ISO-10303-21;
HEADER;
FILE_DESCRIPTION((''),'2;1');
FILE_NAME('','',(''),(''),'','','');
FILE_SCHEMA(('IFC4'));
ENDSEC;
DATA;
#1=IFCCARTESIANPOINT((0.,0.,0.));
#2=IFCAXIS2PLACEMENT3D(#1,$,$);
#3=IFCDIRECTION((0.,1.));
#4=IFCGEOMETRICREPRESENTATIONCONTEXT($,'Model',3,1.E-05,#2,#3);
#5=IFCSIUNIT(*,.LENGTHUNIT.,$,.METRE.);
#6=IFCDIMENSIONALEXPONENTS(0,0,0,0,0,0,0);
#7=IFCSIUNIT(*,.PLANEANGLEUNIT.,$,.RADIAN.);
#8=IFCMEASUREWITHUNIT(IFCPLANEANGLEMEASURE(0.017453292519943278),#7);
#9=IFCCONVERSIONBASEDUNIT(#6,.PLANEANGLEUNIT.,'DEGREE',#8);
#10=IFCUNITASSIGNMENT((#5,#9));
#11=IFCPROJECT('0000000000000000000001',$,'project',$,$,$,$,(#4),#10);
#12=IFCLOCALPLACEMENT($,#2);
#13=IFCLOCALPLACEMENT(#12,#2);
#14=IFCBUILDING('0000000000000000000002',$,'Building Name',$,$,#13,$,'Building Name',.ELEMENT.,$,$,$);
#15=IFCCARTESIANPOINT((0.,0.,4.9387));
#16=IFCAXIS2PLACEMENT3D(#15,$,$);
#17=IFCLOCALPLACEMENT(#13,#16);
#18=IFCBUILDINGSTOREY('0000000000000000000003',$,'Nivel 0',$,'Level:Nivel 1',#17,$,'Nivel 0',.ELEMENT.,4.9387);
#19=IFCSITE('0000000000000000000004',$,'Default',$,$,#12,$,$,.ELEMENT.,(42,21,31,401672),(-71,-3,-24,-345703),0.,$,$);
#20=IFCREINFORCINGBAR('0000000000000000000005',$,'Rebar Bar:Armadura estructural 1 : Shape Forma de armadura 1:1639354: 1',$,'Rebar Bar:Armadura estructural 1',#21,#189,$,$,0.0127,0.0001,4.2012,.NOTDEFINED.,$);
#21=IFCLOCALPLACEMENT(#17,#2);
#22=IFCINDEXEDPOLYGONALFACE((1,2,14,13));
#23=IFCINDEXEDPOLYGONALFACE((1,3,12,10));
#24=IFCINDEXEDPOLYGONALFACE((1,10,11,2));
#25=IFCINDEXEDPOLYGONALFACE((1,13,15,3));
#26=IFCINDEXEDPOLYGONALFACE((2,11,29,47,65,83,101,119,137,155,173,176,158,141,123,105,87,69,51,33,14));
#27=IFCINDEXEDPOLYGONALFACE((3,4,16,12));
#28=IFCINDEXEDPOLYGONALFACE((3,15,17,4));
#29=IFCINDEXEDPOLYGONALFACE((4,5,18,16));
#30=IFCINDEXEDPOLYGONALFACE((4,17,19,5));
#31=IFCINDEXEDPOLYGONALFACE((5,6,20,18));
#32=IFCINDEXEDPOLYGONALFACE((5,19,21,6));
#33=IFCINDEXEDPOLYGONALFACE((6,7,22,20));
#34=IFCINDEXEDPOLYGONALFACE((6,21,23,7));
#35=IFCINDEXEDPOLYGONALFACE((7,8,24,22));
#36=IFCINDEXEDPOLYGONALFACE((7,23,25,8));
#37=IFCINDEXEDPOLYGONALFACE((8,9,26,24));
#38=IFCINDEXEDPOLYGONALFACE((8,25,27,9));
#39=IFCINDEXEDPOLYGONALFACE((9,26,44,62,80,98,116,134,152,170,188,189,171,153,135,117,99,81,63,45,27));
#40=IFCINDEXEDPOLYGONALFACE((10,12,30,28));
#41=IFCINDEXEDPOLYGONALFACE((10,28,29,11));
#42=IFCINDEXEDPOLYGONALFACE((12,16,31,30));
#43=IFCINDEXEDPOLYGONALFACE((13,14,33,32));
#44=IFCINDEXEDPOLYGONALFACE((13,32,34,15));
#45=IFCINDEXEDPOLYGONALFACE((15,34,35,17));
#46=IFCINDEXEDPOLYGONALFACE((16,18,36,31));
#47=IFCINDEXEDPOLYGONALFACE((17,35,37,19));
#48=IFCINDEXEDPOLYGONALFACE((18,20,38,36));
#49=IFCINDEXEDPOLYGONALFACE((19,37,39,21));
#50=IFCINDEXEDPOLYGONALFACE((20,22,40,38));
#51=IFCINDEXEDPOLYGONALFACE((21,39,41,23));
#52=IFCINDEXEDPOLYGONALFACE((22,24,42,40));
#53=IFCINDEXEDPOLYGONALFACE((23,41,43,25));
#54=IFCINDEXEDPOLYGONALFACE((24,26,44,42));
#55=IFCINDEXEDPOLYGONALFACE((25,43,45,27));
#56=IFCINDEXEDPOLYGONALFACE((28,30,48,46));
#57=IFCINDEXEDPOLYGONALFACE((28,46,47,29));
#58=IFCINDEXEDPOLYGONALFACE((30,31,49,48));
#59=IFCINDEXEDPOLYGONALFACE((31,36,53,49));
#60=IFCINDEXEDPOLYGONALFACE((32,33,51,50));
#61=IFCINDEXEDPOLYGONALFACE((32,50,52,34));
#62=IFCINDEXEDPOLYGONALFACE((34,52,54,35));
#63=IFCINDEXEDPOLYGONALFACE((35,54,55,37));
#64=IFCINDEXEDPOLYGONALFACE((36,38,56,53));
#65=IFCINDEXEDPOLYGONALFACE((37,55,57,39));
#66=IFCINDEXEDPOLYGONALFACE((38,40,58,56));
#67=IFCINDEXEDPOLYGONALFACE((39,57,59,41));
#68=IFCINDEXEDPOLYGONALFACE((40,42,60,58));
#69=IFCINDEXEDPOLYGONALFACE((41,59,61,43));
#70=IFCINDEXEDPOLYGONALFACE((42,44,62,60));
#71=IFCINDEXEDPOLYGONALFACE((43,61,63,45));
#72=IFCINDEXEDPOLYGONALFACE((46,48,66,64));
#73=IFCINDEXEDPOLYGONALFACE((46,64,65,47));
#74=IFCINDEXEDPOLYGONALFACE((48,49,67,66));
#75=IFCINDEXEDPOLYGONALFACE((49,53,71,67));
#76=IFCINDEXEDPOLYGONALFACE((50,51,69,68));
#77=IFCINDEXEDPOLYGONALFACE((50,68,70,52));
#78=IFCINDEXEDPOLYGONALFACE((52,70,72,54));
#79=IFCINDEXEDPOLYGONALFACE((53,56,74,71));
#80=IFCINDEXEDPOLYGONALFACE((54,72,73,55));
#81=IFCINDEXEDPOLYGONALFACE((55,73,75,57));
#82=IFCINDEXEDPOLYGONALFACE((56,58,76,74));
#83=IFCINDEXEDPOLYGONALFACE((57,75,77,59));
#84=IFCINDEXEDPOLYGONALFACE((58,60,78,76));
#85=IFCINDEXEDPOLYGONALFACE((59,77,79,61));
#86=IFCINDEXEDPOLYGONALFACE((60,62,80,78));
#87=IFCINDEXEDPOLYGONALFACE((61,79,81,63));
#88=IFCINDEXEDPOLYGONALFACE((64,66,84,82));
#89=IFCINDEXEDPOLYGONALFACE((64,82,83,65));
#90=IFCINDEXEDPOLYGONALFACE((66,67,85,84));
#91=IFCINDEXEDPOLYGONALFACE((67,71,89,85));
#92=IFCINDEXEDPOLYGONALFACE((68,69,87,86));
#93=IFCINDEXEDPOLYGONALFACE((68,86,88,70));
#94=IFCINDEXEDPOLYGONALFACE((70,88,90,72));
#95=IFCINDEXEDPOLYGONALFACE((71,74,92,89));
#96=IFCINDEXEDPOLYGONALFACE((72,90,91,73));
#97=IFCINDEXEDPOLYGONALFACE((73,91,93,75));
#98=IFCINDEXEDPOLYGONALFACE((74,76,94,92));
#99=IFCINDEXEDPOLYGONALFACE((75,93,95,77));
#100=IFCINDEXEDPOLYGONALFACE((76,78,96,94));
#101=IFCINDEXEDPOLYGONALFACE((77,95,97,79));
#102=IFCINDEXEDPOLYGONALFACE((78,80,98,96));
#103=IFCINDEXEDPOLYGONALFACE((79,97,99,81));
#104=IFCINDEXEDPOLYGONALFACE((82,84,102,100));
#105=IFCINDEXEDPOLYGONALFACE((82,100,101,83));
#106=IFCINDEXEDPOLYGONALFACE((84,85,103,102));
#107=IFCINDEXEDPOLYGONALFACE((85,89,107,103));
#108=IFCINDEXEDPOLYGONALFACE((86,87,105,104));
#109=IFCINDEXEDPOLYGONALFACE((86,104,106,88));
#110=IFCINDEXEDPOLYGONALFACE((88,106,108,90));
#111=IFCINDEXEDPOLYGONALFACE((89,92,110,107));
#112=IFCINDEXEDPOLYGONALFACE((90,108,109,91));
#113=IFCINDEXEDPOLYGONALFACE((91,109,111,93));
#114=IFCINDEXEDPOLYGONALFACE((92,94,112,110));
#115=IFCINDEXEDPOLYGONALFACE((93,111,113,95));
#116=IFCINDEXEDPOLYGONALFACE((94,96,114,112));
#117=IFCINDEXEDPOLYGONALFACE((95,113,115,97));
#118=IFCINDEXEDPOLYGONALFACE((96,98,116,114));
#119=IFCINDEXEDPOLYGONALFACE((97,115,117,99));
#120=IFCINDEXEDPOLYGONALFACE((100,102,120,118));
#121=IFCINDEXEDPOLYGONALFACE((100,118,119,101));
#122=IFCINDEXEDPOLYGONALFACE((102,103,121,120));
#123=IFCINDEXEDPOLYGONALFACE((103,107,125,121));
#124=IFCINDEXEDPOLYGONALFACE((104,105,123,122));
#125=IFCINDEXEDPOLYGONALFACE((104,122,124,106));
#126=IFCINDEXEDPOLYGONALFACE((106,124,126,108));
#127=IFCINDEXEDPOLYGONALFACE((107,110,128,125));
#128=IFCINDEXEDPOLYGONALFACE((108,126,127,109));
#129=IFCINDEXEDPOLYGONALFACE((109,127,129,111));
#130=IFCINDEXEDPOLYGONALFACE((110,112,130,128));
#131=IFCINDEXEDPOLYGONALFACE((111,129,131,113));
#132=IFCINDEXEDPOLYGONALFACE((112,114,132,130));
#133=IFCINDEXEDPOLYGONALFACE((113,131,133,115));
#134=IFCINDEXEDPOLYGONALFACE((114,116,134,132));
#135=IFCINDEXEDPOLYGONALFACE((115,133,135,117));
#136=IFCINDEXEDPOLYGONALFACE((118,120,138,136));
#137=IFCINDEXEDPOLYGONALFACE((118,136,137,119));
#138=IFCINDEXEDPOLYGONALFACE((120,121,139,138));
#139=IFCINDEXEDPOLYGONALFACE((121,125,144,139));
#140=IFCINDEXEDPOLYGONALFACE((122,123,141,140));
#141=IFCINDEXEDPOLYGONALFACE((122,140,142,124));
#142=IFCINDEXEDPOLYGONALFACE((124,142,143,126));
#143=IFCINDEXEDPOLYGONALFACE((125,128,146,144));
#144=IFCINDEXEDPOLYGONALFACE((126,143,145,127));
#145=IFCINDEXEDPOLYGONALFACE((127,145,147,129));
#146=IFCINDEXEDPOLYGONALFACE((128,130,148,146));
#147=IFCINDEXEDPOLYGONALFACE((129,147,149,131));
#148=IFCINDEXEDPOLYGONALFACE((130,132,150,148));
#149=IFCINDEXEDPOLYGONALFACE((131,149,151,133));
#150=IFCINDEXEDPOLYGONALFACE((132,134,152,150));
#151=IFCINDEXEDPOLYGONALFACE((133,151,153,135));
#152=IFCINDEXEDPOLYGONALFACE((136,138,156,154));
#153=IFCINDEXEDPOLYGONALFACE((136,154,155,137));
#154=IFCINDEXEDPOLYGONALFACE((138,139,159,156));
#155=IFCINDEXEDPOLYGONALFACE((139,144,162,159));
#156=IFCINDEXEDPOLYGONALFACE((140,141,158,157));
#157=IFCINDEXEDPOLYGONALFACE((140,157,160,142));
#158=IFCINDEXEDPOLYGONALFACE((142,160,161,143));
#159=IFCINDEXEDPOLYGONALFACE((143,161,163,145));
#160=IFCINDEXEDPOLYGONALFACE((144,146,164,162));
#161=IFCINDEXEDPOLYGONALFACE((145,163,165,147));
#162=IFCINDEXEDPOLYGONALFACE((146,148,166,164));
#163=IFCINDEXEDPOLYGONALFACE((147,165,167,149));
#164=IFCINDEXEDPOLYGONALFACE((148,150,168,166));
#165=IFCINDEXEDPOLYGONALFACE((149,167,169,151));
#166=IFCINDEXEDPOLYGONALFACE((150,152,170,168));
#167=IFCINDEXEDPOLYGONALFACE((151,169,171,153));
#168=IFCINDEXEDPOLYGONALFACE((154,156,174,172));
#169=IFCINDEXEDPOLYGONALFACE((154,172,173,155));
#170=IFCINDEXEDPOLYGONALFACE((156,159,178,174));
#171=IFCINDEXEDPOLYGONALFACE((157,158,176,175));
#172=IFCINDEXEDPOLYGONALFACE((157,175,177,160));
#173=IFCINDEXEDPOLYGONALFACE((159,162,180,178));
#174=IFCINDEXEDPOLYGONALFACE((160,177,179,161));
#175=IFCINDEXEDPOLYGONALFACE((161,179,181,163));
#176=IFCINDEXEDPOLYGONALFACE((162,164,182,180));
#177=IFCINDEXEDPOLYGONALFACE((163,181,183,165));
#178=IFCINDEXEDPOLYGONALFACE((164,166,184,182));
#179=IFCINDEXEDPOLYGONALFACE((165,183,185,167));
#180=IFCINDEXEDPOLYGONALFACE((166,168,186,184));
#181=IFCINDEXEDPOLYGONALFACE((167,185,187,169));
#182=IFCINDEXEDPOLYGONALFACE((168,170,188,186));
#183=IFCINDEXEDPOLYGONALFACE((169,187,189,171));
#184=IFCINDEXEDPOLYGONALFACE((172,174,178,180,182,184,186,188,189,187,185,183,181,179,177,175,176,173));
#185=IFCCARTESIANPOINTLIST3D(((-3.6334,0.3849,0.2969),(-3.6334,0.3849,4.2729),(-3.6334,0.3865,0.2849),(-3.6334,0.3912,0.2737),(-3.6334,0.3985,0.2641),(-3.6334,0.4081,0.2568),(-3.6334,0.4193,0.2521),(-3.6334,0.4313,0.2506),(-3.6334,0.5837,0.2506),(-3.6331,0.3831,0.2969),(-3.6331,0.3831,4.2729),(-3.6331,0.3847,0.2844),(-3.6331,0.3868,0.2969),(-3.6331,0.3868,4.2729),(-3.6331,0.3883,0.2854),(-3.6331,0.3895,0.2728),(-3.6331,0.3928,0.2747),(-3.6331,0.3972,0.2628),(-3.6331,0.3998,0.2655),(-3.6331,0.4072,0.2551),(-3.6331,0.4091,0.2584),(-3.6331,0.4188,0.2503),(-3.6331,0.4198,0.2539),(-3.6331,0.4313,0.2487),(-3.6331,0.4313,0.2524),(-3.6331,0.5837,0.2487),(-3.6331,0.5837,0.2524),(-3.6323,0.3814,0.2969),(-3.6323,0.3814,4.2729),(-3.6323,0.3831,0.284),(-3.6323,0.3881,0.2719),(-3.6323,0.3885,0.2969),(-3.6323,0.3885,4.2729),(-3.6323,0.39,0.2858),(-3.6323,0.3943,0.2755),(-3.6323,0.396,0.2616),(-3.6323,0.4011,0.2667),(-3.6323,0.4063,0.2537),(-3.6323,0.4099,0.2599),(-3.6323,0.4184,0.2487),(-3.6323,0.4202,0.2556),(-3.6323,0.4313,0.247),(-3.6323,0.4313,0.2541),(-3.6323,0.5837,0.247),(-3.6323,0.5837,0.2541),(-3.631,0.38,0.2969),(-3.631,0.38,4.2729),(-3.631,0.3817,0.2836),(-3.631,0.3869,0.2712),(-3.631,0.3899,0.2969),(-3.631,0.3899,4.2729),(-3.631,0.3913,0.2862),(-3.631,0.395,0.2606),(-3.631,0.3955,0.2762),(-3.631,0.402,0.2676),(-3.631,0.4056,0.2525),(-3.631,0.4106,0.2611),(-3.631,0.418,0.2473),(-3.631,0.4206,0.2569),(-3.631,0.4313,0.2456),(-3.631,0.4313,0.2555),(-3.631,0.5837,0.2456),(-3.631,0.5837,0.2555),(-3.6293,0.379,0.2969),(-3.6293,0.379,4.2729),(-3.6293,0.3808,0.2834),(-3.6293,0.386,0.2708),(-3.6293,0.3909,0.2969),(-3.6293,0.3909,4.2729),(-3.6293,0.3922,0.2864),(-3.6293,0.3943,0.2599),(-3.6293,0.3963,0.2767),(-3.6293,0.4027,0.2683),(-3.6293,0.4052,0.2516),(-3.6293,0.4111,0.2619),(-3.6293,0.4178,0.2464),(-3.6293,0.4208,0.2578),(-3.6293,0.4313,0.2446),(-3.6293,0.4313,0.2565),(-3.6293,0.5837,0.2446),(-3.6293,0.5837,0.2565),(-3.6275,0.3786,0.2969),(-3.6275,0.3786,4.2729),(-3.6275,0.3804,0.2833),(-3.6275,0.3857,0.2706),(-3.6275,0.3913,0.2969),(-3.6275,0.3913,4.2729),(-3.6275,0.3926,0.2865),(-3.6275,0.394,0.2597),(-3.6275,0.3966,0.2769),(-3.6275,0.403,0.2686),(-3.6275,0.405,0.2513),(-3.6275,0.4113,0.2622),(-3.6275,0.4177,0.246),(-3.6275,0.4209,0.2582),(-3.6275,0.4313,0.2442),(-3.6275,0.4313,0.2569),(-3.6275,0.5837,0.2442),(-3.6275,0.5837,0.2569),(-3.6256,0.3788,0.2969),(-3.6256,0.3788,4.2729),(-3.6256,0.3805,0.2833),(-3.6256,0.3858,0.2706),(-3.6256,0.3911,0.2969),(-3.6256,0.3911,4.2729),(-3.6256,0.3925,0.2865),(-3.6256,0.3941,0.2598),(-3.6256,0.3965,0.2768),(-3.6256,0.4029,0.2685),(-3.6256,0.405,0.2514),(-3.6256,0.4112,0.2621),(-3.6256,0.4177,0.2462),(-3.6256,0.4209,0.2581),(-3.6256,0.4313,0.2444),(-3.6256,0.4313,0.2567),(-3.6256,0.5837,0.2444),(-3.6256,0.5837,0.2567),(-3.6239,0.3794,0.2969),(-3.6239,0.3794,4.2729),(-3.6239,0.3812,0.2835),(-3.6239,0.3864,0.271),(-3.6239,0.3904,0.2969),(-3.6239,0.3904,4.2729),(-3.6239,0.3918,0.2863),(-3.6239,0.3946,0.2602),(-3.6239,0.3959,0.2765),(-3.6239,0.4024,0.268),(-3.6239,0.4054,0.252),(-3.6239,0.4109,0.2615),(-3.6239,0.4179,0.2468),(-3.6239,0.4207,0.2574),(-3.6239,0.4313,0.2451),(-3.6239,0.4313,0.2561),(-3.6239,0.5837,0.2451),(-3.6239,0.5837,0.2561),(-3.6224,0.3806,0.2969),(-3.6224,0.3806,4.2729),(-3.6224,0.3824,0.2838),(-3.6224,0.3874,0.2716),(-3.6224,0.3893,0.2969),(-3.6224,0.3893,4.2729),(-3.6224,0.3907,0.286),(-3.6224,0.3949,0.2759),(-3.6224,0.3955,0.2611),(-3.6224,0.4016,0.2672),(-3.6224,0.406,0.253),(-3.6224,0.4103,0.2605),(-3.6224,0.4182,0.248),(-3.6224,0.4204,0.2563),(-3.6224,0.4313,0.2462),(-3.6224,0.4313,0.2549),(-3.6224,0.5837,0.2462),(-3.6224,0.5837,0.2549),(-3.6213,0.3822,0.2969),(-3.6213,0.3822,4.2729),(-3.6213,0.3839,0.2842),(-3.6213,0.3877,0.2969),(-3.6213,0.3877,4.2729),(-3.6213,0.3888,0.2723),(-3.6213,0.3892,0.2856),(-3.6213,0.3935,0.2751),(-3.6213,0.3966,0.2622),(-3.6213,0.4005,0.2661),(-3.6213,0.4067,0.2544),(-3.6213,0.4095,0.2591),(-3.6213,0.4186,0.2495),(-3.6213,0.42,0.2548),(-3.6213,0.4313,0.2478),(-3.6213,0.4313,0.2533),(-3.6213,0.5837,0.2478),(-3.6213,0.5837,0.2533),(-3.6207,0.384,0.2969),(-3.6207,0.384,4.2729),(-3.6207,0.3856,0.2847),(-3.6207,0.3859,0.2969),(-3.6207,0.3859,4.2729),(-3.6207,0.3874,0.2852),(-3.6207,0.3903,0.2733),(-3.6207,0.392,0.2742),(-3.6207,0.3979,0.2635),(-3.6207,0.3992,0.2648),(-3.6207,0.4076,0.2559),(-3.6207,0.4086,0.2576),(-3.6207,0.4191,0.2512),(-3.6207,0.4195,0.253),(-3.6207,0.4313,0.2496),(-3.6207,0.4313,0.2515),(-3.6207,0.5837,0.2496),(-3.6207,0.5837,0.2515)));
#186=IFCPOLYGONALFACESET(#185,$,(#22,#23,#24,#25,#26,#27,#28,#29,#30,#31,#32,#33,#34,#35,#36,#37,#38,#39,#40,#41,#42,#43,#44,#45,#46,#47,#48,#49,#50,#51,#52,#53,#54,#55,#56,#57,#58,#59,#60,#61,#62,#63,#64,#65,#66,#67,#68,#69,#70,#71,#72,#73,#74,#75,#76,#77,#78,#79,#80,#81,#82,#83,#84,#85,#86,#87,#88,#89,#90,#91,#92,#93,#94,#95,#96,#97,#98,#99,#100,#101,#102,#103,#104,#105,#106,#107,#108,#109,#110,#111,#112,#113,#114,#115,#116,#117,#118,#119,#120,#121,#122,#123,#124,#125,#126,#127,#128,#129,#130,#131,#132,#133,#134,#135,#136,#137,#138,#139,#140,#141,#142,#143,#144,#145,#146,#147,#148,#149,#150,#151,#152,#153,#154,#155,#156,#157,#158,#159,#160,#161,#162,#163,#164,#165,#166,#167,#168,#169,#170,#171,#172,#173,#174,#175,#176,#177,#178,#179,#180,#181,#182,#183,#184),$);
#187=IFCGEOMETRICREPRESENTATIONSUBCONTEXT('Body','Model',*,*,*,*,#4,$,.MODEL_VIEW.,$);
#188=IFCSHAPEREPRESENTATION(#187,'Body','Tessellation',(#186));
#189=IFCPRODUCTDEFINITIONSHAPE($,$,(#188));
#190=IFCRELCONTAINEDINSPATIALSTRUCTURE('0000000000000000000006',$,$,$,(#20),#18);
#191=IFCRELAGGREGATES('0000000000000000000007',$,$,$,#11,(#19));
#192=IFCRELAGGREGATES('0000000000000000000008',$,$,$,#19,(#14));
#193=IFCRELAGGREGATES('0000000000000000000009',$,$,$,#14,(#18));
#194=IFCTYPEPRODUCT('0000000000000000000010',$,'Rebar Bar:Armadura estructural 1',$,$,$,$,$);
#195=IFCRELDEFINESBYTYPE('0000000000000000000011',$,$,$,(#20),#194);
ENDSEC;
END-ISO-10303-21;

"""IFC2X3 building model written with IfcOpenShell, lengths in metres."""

from ifc_helpers import new_model, entity, si_unit, converted_unit, direction, frame, origin, place, context, subcontext, project, spatial, type_object, element, save


model = new_model("IFC2X3")

# Units and contexts
model_context = context("Model", 3, precision=1e-05, world=origin(), true_north=direction((0.0, 1.0)))
body_context = subcontext(model_context, "Body", "Model", "MODEL_VIEW")
ifc_project = project(units=[si_unit("LENGTHUNIT", "METRE"), converted_unit("PLANEANGLEUNIT", "DEGREE", entity("IfcPlaneAngleMeasure", 0.017453292519943278), si_unit("PLANEANGLEUNIT", "RADIAN"), dimensions=[0, 0, 0, 0, 0, 0, 0])], contexts=[model_context])

# Site, building, storey
site_placement = place(None, origin())
site = spatial("IfcSite", under=ifc_project, at=site_placement, Name="Default", CompositionType="ELEMENT", RefLatitude=(42, 21, 31, 401672), RefLongitude=(-71, -3, -24, -345703), RefElevation=0.0)
building_placement = place(site_placement, origin())
building = spatial("IfcBuilding", under=site, at=building_placement, Name="Building Name", LongName="Building Name", CompositionType="ELEMENT")
storey_placement = place(building_placement, frame((0.0, 0.0, 4.9387)))
storey = spatial("IfcBuildingStorey", under=building, at=storey_placement, Name="Nivel 0", ObjectType="Level:Nivel 1", LongName="Nivel 0", CompositionType="ELEMENT", Elevation=4.9387)

# Reinforcing bar
type_product = type_object("IfcTypeProduct", Name="Rebar Bar:Armadura estructural 1")
reinforcing_bar_1_placement = place(storey_placement, origin())
element("IfcReinforcingBar", 1, at=reinforcing_bar_1_placement, inside=storey, type_object=type_product, Name="Rebar Bar:Armadura estructural 1 : Shape Forma de armadura 1:1639354: 1", ObjectType="Rebar Bar:Armadura estructural 1", BarLength=4.2012, BarRole="NOTDEFINED", CrossSectionArea=0.0001, NominalDiameter=0.0127, context=body_context, shape_type="AdvancedSweptSolid", body=[
    entity("IfcSweptDiskSolid", entity("IfcCompositeCurve", [entity("IfcCompositeCurveSegment", "CONTINUOUS", True, entity("IfcPolyline", [entity("IfcCartesianPoint", [-3.627, 0.5837, 0.2506]), entity("IfcCartesianPoint", [-3.627, 0.4313, 0.2506])])), entity("IfcCompositeCurveSegment", "CONTINUOUS", True, entity("IfcTrimmedCurve", entity("IfcCircle", entity("IfcAxis2Placement3D", entity("IfcCartesianPoint", [-3.627, 0.4313, 0.2969]), entity("IfcDirection", [-1.0, 0.0, 0.0]), entity("IfcDirection", [0.0, -1.0, 0.0])), 0.0464), [entity("IfcParameterValue", 270.0)], [entity("IfcParameterValue", 360.0)], True, "PARAMETER")), entity("IfcCompositeCurveSegment", "CONTINUOUS", True, entity("IfcPolyline", [entity("IfcCartesianPoint", [-3.627, 0.3849, 0.2969]), entity("IfcCartesianPoint", [-3.627, 0.3849, 4.2729])]))], False), 0.0063, None, 0.0, 92.0),
])

save(model, "model.ifc")
